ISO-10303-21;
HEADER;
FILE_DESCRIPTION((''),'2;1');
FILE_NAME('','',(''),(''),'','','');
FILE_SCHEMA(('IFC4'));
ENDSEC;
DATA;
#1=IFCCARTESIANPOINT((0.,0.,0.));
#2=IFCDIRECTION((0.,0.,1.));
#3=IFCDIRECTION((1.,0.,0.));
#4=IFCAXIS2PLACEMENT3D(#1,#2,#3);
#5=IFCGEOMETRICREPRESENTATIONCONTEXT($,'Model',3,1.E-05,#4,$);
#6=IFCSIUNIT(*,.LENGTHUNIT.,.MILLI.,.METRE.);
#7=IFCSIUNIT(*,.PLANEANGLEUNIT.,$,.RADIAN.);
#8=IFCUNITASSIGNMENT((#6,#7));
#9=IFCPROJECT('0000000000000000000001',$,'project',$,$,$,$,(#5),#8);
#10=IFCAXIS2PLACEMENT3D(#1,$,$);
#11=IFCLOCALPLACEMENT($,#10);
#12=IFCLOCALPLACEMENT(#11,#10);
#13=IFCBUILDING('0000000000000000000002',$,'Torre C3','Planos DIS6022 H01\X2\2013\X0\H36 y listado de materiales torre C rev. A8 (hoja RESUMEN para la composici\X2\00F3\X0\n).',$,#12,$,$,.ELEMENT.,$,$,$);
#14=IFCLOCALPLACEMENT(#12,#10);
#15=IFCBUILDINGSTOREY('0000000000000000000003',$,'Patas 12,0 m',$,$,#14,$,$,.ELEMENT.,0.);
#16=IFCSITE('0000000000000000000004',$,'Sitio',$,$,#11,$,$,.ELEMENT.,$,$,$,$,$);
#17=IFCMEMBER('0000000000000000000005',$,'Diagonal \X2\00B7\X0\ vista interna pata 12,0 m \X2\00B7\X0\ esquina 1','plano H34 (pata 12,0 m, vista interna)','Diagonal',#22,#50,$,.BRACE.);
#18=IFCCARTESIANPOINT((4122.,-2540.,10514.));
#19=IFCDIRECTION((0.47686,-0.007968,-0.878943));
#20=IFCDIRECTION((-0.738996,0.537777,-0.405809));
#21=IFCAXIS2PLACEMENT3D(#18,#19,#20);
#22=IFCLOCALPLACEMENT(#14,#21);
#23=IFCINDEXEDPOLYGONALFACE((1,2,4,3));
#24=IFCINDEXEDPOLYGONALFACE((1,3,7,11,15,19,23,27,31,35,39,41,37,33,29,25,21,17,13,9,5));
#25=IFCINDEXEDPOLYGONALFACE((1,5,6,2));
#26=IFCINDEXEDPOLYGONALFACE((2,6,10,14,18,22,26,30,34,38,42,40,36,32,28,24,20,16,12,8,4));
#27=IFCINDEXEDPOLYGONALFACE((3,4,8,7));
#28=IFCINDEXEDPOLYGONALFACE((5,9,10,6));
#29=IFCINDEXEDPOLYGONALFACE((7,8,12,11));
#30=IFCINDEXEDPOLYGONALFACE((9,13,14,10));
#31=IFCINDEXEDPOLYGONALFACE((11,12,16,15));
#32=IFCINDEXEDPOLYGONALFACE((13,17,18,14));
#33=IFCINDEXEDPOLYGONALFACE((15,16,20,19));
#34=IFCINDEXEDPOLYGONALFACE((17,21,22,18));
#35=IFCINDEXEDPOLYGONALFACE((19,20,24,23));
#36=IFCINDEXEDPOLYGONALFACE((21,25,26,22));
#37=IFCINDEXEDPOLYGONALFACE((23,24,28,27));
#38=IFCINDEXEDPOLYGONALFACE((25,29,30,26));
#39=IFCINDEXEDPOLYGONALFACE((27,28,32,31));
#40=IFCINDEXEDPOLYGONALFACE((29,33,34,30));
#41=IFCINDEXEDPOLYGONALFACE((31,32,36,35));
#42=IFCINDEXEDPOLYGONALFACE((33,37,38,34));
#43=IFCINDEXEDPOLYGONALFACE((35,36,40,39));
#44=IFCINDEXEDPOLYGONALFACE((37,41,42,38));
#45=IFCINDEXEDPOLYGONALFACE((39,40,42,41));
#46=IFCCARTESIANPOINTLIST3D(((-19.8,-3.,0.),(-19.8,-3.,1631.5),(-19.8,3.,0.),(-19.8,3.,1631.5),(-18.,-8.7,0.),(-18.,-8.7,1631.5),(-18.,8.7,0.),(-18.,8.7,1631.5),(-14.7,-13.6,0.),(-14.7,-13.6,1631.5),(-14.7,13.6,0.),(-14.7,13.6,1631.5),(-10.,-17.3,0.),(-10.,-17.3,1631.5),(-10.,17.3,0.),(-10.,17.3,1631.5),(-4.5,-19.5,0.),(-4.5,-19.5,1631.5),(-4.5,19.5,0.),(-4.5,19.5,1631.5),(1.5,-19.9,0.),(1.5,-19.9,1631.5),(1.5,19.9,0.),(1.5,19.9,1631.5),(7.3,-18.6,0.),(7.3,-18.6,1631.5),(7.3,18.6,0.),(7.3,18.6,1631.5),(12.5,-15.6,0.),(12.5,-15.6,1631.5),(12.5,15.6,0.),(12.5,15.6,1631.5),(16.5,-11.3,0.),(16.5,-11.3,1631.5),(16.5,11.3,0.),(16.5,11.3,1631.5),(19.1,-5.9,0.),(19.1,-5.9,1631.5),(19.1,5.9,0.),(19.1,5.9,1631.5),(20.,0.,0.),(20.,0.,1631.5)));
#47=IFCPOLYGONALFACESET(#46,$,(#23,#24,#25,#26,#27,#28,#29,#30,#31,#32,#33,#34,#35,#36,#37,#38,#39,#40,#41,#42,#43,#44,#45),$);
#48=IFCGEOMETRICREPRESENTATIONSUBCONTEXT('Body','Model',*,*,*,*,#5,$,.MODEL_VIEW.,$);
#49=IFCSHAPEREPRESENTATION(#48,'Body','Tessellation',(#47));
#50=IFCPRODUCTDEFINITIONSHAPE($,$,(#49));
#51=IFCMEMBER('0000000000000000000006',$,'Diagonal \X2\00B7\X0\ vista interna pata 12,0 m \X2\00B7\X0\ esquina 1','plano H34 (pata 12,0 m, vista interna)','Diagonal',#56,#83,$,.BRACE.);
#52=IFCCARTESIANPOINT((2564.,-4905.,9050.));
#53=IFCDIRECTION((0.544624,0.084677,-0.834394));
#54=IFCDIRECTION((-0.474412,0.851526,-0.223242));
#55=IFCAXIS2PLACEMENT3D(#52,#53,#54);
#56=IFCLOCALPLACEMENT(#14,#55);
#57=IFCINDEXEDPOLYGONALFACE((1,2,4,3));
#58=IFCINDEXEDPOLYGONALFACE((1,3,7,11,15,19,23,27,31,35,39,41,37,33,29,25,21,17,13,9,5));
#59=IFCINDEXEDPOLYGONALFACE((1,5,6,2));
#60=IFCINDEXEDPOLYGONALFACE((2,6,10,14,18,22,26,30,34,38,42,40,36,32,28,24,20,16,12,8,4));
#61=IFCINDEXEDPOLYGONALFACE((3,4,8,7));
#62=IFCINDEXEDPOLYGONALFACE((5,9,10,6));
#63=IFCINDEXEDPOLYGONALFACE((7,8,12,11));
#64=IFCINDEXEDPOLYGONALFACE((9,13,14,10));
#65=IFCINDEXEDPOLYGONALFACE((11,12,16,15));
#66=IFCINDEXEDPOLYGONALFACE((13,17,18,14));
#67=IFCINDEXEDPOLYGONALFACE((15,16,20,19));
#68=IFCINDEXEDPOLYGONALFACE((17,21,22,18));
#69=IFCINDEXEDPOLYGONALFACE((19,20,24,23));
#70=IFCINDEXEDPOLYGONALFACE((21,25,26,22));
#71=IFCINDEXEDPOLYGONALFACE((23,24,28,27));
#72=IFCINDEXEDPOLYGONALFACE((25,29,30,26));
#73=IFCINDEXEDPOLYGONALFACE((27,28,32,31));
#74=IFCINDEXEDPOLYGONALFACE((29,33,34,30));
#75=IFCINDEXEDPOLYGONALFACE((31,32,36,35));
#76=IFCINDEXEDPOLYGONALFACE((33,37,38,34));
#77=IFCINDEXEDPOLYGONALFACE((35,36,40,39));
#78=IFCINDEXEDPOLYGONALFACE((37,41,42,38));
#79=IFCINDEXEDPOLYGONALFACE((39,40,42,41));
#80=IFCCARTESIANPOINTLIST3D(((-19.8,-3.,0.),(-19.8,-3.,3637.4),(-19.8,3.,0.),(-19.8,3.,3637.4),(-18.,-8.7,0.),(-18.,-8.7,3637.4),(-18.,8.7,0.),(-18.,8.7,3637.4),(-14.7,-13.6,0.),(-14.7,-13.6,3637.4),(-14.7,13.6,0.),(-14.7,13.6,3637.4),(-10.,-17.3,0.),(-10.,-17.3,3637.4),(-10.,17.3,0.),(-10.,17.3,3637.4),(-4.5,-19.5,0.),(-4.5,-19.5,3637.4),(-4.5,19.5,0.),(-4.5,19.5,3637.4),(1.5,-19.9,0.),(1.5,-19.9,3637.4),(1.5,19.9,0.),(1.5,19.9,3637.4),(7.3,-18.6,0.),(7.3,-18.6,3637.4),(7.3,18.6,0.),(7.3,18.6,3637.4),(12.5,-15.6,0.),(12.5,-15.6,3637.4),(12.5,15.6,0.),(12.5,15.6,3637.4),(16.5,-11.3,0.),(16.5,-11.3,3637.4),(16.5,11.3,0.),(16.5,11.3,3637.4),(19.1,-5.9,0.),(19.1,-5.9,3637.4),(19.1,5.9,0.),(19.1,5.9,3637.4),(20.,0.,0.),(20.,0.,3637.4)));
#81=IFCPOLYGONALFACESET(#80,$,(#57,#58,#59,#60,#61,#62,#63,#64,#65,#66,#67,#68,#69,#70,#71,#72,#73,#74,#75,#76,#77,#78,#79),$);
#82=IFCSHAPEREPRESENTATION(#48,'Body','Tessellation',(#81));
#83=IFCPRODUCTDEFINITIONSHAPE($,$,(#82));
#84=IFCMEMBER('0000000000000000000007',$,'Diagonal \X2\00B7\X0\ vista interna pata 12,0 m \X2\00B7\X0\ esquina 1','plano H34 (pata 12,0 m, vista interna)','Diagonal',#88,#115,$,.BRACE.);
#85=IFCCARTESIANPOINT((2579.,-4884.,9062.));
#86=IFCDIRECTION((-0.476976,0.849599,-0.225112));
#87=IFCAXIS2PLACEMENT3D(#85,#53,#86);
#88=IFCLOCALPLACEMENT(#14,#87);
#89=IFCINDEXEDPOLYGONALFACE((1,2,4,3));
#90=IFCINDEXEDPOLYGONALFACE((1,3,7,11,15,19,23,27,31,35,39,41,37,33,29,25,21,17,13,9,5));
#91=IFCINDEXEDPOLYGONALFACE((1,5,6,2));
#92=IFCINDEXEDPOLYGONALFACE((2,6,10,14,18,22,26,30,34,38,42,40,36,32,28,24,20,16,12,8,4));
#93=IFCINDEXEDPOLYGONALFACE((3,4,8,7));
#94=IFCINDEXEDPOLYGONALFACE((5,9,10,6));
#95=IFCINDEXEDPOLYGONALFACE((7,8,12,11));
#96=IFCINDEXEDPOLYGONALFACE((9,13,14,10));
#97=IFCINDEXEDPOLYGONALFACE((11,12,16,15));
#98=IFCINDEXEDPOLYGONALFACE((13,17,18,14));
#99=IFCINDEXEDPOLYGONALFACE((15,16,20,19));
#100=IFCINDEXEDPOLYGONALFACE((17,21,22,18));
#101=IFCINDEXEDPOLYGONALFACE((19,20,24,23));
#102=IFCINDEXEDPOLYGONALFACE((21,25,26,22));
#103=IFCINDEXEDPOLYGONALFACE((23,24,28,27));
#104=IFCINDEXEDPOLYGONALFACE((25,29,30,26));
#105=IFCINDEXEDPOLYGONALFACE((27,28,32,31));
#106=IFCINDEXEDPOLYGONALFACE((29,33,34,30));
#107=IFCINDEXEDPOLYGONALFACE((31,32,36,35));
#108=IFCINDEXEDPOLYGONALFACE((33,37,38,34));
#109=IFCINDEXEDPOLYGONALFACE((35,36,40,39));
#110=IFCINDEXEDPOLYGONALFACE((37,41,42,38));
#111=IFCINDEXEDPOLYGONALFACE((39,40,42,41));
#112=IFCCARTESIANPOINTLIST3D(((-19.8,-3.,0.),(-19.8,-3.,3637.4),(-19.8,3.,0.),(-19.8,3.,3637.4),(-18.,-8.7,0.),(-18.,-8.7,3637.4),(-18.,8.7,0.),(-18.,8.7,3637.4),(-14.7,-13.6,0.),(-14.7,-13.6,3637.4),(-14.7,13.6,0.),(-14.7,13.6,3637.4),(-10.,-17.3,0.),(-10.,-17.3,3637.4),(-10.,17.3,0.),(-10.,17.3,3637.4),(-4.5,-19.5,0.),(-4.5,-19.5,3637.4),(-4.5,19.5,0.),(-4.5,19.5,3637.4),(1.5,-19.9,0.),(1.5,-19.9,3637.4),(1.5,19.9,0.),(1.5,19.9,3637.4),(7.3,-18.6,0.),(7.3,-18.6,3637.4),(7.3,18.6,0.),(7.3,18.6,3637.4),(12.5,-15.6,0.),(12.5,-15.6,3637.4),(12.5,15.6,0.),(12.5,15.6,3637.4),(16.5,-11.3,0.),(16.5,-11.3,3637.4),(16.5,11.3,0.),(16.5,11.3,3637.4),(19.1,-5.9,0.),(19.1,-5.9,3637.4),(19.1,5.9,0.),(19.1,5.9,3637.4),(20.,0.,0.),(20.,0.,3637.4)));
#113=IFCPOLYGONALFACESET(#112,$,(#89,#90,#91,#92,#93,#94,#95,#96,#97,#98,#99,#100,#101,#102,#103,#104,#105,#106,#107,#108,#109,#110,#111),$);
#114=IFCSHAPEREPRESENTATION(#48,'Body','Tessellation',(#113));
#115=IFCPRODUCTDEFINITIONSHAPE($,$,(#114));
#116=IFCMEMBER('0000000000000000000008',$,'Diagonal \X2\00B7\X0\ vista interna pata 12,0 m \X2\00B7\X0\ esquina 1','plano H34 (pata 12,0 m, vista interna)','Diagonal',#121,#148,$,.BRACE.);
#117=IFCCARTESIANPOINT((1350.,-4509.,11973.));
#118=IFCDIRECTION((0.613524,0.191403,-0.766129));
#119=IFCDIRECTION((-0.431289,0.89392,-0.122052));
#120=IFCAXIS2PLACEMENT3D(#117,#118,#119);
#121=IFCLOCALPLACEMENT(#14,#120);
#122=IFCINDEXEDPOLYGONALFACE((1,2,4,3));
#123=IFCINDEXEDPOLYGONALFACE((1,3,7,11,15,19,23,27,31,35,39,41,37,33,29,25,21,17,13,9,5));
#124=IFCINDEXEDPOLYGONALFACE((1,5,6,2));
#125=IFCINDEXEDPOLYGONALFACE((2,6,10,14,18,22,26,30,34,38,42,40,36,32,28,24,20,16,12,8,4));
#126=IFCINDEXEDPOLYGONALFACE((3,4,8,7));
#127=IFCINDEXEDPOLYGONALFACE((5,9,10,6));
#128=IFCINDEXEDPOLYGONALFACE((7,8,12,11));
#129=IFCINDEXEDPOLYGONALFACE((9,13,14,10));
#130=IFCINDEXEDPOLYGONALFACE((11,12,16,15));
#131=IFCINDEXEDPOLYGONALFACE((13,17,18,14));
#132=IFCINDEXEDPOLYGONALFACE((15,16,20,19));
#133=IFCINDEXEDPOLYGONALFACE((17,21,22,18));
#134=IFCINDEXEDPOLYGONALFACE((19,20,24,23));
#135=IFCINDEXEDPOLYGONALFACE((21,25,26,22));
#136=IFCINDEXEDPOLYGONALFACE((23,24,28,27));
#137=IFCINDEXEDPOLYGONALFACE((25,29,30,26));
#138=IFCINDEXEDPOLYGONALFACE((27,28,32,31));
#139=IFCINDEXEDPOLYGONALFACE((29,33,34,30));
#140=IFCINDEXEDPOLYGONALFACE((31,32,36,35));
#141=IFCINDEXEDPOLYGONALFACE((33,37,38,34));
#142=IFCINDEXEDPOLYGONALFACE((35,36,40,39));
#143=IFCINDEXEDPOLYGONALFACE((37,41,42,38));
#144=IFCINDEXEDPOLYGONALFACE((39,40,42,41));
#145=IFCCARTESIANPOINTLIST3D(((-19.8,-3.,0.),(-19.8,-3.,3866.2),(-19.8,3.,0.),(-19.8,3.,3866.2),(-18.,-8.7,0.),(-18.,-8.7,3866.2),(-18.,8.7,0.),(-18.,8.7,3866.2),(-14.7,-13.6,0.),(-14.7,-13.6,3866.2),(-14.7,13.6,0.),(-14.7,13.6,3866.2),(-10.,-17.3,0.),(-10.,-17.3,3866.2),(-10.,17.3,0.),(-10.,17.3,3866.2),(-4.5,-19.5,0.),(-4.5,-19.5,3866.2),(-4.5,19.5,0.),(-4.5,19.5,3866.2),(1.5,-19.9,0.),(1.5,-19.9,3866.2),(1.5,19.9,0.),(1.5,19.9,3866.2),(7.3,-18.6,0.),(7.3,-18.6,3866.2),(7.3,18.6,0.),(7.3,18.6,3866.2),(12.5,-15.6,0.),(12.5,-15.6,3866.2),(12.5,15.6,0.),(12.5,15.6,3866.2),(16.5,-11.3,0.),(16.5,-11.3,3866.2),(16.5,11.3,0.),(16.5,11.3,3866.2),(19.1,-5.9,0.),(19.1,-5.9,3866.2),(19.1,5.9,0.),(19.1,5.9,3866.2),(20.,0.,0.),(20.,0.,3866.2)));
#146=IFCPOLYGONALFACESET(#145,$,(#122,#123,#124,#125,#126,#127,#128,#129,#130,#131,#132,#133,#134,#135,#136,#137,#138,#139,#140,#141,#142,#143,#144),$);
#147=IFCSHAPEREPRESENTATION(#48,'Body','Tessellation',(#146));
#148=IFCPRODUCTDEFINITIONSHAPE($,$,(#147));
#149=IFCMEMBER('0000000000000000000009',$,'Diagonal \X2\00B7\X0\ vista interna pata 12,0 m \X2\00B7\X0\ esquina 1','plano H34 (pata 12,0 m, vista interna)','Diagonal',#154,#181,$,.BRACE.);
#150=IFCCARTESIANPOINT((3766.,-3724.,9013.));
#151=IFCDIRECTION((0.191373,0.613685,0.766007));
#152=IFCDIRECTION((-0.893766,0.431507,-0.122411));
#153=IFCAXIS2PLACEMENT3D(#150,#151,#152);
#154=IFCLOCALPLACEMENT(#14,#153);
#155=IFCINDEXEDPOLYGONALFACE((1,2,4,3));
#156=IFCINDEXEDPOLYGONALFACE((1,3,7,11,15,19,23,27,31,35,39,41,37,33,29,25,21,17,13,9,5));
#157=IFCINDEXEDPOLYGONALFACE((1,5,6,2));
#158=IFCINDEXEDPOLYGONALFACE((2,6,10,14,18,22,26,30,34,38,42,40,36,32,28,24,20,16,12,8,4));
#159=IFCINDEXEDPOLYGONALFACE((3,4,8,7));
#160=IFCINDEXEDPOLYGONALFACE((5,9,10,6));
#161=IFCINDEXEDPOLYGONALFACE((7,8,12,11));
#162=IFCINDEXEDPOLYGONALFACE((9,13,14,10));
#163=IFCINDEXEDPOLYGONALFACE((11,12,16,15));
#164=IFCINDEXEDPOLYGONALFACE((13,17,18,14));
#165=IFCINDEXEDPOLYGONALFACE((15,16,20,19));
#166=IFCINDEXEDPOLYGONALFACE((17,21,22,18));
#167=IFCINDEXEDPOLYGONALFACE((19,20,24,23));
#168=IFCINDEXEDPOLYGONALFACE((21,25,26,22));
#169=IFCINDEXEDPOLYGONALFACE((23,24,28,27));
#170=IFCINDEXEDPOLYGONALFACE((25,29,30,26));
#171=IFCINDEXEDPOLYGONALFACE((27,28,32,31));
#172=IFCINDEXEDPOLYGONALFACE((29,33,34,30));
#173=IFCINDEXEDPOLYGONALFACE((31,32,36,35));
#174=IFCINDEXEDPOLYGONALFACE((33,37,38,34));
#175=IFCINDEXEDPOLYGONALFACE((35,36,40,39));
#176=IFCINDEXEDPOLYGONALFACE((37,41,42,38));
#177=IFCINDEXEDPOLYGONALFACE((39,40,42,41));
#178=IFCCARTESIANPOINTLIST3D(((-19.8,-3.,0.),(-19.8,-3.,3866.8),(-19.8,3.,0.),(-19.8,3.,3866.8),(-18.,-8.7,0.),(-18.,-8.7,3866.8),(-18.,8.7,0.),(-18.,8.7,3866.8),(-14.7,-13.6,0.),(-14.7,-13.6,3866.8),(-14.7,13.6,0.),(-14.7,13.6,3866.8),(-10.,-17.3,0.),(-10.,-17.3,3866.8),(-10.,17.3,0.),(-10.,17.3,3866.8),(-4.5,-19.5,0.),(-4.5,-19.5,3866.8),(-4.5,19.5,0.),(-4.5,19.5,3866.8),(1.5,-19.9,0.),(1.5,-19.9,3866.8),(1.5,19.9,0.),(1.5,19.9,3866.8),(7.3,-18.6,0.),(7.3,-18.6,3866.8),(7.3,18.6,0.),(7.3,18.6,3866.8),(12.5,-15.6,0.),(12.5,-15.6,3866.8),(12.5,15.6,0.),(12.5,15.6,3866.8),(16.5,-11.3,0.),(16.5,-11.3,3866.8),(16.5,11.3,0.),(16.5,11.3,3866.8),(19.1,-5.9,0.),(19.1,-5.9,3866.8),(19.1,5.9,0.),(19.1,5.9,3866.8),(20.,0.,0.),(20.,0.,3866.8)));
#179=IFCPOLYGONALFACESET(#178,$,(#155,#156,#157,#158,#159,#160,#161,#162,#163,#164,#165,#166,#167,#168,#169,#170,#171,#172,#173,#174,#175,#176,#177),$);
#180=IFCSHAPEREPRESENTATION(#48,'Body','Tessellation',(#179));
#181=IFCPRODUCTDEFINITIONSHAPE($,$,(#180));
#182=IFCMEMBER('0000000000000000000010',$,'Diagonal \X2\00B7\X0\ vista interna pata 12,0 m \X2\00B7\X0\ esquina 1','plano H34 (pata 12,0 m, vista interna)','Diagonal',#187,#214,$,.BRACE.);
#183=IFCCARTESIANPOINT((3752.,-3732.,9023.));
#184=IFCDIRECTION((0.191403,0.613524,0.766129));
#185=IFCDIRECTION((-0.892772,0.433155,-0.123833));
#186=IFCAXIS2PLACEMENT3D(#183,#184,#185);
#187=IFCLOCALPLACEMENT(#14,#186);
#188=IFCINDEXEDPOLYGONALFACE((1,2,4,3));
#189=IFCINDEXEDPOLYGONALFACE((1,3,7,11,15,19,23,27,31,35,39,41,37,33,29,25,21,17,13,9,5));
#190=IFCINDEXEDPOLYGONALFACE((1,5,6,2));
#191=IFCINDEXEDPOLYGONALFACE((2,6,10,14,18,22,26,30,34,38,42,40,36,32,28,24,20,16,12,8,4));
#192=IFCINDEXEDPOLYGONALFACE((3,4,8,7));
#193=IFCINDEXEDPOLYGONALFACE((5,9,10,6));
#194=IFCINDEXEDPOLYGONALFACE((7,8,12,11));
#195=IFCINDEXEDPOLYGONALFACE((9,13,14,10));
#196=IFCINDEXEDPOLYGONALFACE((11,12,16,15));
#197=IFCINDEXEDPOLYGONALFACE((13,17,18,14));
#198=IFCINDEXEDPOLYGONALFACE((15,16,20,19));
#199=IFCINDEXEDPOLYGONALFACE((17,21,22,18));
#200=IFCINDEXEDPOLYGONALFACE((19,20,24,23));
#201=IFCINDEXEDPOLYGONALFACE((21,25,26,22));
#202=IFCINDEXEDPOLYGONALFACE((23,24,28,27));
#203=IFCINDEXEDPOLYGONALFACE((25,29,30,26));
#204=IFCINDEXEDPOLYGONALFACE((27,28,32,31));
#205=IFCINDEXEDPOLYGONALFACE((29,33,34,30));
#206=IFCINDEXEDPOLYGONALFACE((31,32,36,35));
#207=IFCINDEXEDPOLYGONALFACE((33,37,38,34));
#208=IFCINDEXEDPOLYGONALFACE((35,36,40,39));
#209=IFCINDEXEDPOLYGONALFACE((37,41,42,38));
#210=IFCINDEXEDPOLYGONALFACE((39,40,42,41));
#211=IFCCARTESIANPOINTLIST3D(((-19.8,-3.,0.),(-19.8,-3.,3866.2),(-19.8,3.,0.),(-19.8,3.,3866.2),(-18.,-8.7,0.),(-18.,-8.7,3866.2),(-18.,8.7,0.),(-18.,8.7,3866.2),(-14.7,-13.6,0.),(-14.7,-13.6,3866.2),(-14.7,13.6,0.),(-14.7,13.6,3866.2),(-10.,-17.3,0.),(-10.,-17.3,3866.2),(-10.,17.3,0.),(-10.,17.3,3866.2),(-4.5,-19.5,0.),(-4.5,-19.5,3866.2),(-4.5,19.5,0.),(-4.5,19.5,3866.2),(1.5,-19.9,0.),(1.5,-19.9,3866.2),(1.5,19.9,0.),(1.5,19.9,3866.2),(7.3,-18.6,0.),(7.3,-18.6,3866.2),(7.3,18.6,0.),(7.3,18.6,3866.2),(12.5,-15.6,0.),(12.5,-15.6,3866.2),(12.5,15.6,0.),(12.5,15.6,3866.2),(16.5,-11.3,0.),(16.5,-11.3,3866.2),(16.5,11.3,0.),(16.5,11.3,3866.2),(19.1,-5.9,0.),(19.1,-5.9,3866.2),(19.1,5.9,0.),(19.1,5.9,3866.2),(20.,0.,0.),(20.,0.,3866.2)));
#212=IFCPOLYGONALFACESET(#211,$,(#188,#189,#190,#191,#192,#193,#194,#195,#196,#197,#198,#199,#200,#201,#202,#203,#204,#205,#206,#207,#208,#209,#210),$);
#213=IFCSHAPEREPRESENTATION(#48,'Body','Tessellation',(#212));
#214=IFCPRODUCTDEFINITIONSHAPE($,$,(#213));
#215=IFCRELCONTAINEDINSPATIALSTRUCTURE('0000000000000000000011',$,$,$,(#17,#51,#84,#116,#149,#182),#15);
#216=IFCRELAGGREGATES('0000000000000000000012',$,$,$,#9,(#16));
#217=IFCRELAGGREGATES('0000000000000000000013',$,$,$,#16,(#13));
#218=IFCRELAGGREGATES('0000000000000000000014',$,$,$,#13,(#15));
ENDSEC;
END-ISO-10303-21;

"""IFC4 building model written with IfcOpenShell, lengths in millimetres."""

from ifc_helpers import new_model, si_unit, frame, origin, origin_with_axes, place, context, subcontext, project, spatial, circle, extrude, element, save


model = new_model("IFC4")

# Units and contexts
model_context = context("Model", 3, precision=1e-05, world=origin_with_axes())
body_context = subcontext(model_context, "Body", "Model", "MODEL_VIEW")
ifc_project = project(units=[si_unit("LENGTHUNIT", "METRE", prefix="MILLI"), si_unit("PLANEANGLEUNIT", "RADIAN")], contexts=[model_context])

# Site, building, storey
site_placement = place(None, origin())
site = spatial("IfcSite", under=ifc_project, at=site_placement, Name="Sitio", CompositionType="ELEMENT")
building_placement = place(site_placement, origin())
building = spatial("IfcBuilding", under=site, at=building_placement, Name="Torre C3", Description="Planos DIS6022 H01–H36 y listado de materiales torre C rev. A8 (hoja RESUMEN para la composición).", CompositionType="ELEMENT")
storey_placement = place(building_placement, origin())
storey = spatial("IfcBuildingStorey", under=building, at=storey_placement, Name="Patas 12,0 m", CompositionType="ELEMENT", Elevation=0.0)

# Members
member_1_placement = place(storey_placement, frame((4122.0, -2540.0, 10514.0), z_axis=(0.47686, -0.007968, -0.878943), x_axis=(-0.738996, 0.537777, -0.405809)))
element("IfcMember", 1, at=member_1_placement, inside=storey, Name="Diagonal · vista interna pata 12,0 m · esquina 1", Description="plano H34 (pata 12,0 m, vista interna)", ObjectType="Diagonal", PredefinedType="BRACE", context=body_context, shape_type="SweptSolid", body=[
    extrude(circle(Radius=20.0), None, (0.0, 0.0, 1.0), 1631.5),
])
for number, where, z_axis, x_axis, name in (
    (2, (2564.0, -4905.0, 9050.0), (0.544624, 0.084677, -0.834394), (-0.474412, 0.851526, -0.223242), "Diagonal · vista interna pata 12,0 m · esquina 1"),
    (3, (2579.0, -4884.0, 9062.0), (0.544624, 0.084677, -0.834394), (-0.476976, 0.849599, -0.225112), "Diagonal · vista interna pata 12,0 m · esquina 1"),
):
    element("IfcMember", number, at=place(storey_placement, frame(where, z_axis=z_axis, x_axis=x_axis)), inside=storey, Name=name, Description="plano H34 (pata 12,0 m, vista interna)", ObjectType="Diagonal", PredefinedType="BRACE", context=body_context, shape_type="SweptSolid", body=[
        extrude(circle(Radius=20.0), None, (0.0, 0.0, 1.0), 3637.4),
    ])
member_2_placement = place(storey_placement, frame((1350.0, -4509.0, 11973.0), z_axis=(0.613524, 0.191403, -0.766129), x_axis=(-0.431289, 0.89392, -0.122052)))
element("IfcMember", 4, at=member_2_placement, inside=storey, Name="Diagonal · vista interna pata 12,0 m · esquina 1", Description="plano H34 (pata 12,0 m, vista interna)", ObjectType="Diagonal", PredefinedType="BRACE", context=body_context, shape_type="SweptSolid", body=[
    extrude(circle(Radius=20.0), None, (0.0, 0.0, 1.0), 3866.2),
])
member_3_placement = place(storey_placement, frame((3766.0, -3724.0, 9013.0), z_axis=(0.191373, 0.613685, 0.766007), x_axis=(-0.893766, 0.431507, -0.122411)))
element("IfcMember", 5, at=member_3_placement, inside=storey, Name="Diagonal · vista interna pata 12,0 m · esquina 1", Description="plano H34 (pata 12,0 m, vista interna)", ObjectType="Diagonal", PredefinedType="BRACE", context=body_context, shape_type="SweptSolid", body=[
    extrude(circle(Radius=20.0), None, (0.0, 0.0, 1.0), 3866.8),
])
member_4_placement = place(storey_placement, frame((3752.0, -3732.0, 9023.0), z_axis=(0.191403, 0.613524, 0.766129), x_axis=(-0.892772, 0.433155, -0.123833)))
element("IfcMember", 6, at=member_4_placement, inside=storey, Name="Diagonal · vista interna pata 12,0 m · esquina 1", Description="plano H34 (pata 12,0 m, vista interna)", ObjectType="Diagonal", PredefinedType="BRACE", context=body_context, shape_type="SweptSolid", body=[
    extrude(circle(Radius=20.0), None, (0.0, 0.0, 1.0), 3866.2),
])

save(model, "model.ifc")
